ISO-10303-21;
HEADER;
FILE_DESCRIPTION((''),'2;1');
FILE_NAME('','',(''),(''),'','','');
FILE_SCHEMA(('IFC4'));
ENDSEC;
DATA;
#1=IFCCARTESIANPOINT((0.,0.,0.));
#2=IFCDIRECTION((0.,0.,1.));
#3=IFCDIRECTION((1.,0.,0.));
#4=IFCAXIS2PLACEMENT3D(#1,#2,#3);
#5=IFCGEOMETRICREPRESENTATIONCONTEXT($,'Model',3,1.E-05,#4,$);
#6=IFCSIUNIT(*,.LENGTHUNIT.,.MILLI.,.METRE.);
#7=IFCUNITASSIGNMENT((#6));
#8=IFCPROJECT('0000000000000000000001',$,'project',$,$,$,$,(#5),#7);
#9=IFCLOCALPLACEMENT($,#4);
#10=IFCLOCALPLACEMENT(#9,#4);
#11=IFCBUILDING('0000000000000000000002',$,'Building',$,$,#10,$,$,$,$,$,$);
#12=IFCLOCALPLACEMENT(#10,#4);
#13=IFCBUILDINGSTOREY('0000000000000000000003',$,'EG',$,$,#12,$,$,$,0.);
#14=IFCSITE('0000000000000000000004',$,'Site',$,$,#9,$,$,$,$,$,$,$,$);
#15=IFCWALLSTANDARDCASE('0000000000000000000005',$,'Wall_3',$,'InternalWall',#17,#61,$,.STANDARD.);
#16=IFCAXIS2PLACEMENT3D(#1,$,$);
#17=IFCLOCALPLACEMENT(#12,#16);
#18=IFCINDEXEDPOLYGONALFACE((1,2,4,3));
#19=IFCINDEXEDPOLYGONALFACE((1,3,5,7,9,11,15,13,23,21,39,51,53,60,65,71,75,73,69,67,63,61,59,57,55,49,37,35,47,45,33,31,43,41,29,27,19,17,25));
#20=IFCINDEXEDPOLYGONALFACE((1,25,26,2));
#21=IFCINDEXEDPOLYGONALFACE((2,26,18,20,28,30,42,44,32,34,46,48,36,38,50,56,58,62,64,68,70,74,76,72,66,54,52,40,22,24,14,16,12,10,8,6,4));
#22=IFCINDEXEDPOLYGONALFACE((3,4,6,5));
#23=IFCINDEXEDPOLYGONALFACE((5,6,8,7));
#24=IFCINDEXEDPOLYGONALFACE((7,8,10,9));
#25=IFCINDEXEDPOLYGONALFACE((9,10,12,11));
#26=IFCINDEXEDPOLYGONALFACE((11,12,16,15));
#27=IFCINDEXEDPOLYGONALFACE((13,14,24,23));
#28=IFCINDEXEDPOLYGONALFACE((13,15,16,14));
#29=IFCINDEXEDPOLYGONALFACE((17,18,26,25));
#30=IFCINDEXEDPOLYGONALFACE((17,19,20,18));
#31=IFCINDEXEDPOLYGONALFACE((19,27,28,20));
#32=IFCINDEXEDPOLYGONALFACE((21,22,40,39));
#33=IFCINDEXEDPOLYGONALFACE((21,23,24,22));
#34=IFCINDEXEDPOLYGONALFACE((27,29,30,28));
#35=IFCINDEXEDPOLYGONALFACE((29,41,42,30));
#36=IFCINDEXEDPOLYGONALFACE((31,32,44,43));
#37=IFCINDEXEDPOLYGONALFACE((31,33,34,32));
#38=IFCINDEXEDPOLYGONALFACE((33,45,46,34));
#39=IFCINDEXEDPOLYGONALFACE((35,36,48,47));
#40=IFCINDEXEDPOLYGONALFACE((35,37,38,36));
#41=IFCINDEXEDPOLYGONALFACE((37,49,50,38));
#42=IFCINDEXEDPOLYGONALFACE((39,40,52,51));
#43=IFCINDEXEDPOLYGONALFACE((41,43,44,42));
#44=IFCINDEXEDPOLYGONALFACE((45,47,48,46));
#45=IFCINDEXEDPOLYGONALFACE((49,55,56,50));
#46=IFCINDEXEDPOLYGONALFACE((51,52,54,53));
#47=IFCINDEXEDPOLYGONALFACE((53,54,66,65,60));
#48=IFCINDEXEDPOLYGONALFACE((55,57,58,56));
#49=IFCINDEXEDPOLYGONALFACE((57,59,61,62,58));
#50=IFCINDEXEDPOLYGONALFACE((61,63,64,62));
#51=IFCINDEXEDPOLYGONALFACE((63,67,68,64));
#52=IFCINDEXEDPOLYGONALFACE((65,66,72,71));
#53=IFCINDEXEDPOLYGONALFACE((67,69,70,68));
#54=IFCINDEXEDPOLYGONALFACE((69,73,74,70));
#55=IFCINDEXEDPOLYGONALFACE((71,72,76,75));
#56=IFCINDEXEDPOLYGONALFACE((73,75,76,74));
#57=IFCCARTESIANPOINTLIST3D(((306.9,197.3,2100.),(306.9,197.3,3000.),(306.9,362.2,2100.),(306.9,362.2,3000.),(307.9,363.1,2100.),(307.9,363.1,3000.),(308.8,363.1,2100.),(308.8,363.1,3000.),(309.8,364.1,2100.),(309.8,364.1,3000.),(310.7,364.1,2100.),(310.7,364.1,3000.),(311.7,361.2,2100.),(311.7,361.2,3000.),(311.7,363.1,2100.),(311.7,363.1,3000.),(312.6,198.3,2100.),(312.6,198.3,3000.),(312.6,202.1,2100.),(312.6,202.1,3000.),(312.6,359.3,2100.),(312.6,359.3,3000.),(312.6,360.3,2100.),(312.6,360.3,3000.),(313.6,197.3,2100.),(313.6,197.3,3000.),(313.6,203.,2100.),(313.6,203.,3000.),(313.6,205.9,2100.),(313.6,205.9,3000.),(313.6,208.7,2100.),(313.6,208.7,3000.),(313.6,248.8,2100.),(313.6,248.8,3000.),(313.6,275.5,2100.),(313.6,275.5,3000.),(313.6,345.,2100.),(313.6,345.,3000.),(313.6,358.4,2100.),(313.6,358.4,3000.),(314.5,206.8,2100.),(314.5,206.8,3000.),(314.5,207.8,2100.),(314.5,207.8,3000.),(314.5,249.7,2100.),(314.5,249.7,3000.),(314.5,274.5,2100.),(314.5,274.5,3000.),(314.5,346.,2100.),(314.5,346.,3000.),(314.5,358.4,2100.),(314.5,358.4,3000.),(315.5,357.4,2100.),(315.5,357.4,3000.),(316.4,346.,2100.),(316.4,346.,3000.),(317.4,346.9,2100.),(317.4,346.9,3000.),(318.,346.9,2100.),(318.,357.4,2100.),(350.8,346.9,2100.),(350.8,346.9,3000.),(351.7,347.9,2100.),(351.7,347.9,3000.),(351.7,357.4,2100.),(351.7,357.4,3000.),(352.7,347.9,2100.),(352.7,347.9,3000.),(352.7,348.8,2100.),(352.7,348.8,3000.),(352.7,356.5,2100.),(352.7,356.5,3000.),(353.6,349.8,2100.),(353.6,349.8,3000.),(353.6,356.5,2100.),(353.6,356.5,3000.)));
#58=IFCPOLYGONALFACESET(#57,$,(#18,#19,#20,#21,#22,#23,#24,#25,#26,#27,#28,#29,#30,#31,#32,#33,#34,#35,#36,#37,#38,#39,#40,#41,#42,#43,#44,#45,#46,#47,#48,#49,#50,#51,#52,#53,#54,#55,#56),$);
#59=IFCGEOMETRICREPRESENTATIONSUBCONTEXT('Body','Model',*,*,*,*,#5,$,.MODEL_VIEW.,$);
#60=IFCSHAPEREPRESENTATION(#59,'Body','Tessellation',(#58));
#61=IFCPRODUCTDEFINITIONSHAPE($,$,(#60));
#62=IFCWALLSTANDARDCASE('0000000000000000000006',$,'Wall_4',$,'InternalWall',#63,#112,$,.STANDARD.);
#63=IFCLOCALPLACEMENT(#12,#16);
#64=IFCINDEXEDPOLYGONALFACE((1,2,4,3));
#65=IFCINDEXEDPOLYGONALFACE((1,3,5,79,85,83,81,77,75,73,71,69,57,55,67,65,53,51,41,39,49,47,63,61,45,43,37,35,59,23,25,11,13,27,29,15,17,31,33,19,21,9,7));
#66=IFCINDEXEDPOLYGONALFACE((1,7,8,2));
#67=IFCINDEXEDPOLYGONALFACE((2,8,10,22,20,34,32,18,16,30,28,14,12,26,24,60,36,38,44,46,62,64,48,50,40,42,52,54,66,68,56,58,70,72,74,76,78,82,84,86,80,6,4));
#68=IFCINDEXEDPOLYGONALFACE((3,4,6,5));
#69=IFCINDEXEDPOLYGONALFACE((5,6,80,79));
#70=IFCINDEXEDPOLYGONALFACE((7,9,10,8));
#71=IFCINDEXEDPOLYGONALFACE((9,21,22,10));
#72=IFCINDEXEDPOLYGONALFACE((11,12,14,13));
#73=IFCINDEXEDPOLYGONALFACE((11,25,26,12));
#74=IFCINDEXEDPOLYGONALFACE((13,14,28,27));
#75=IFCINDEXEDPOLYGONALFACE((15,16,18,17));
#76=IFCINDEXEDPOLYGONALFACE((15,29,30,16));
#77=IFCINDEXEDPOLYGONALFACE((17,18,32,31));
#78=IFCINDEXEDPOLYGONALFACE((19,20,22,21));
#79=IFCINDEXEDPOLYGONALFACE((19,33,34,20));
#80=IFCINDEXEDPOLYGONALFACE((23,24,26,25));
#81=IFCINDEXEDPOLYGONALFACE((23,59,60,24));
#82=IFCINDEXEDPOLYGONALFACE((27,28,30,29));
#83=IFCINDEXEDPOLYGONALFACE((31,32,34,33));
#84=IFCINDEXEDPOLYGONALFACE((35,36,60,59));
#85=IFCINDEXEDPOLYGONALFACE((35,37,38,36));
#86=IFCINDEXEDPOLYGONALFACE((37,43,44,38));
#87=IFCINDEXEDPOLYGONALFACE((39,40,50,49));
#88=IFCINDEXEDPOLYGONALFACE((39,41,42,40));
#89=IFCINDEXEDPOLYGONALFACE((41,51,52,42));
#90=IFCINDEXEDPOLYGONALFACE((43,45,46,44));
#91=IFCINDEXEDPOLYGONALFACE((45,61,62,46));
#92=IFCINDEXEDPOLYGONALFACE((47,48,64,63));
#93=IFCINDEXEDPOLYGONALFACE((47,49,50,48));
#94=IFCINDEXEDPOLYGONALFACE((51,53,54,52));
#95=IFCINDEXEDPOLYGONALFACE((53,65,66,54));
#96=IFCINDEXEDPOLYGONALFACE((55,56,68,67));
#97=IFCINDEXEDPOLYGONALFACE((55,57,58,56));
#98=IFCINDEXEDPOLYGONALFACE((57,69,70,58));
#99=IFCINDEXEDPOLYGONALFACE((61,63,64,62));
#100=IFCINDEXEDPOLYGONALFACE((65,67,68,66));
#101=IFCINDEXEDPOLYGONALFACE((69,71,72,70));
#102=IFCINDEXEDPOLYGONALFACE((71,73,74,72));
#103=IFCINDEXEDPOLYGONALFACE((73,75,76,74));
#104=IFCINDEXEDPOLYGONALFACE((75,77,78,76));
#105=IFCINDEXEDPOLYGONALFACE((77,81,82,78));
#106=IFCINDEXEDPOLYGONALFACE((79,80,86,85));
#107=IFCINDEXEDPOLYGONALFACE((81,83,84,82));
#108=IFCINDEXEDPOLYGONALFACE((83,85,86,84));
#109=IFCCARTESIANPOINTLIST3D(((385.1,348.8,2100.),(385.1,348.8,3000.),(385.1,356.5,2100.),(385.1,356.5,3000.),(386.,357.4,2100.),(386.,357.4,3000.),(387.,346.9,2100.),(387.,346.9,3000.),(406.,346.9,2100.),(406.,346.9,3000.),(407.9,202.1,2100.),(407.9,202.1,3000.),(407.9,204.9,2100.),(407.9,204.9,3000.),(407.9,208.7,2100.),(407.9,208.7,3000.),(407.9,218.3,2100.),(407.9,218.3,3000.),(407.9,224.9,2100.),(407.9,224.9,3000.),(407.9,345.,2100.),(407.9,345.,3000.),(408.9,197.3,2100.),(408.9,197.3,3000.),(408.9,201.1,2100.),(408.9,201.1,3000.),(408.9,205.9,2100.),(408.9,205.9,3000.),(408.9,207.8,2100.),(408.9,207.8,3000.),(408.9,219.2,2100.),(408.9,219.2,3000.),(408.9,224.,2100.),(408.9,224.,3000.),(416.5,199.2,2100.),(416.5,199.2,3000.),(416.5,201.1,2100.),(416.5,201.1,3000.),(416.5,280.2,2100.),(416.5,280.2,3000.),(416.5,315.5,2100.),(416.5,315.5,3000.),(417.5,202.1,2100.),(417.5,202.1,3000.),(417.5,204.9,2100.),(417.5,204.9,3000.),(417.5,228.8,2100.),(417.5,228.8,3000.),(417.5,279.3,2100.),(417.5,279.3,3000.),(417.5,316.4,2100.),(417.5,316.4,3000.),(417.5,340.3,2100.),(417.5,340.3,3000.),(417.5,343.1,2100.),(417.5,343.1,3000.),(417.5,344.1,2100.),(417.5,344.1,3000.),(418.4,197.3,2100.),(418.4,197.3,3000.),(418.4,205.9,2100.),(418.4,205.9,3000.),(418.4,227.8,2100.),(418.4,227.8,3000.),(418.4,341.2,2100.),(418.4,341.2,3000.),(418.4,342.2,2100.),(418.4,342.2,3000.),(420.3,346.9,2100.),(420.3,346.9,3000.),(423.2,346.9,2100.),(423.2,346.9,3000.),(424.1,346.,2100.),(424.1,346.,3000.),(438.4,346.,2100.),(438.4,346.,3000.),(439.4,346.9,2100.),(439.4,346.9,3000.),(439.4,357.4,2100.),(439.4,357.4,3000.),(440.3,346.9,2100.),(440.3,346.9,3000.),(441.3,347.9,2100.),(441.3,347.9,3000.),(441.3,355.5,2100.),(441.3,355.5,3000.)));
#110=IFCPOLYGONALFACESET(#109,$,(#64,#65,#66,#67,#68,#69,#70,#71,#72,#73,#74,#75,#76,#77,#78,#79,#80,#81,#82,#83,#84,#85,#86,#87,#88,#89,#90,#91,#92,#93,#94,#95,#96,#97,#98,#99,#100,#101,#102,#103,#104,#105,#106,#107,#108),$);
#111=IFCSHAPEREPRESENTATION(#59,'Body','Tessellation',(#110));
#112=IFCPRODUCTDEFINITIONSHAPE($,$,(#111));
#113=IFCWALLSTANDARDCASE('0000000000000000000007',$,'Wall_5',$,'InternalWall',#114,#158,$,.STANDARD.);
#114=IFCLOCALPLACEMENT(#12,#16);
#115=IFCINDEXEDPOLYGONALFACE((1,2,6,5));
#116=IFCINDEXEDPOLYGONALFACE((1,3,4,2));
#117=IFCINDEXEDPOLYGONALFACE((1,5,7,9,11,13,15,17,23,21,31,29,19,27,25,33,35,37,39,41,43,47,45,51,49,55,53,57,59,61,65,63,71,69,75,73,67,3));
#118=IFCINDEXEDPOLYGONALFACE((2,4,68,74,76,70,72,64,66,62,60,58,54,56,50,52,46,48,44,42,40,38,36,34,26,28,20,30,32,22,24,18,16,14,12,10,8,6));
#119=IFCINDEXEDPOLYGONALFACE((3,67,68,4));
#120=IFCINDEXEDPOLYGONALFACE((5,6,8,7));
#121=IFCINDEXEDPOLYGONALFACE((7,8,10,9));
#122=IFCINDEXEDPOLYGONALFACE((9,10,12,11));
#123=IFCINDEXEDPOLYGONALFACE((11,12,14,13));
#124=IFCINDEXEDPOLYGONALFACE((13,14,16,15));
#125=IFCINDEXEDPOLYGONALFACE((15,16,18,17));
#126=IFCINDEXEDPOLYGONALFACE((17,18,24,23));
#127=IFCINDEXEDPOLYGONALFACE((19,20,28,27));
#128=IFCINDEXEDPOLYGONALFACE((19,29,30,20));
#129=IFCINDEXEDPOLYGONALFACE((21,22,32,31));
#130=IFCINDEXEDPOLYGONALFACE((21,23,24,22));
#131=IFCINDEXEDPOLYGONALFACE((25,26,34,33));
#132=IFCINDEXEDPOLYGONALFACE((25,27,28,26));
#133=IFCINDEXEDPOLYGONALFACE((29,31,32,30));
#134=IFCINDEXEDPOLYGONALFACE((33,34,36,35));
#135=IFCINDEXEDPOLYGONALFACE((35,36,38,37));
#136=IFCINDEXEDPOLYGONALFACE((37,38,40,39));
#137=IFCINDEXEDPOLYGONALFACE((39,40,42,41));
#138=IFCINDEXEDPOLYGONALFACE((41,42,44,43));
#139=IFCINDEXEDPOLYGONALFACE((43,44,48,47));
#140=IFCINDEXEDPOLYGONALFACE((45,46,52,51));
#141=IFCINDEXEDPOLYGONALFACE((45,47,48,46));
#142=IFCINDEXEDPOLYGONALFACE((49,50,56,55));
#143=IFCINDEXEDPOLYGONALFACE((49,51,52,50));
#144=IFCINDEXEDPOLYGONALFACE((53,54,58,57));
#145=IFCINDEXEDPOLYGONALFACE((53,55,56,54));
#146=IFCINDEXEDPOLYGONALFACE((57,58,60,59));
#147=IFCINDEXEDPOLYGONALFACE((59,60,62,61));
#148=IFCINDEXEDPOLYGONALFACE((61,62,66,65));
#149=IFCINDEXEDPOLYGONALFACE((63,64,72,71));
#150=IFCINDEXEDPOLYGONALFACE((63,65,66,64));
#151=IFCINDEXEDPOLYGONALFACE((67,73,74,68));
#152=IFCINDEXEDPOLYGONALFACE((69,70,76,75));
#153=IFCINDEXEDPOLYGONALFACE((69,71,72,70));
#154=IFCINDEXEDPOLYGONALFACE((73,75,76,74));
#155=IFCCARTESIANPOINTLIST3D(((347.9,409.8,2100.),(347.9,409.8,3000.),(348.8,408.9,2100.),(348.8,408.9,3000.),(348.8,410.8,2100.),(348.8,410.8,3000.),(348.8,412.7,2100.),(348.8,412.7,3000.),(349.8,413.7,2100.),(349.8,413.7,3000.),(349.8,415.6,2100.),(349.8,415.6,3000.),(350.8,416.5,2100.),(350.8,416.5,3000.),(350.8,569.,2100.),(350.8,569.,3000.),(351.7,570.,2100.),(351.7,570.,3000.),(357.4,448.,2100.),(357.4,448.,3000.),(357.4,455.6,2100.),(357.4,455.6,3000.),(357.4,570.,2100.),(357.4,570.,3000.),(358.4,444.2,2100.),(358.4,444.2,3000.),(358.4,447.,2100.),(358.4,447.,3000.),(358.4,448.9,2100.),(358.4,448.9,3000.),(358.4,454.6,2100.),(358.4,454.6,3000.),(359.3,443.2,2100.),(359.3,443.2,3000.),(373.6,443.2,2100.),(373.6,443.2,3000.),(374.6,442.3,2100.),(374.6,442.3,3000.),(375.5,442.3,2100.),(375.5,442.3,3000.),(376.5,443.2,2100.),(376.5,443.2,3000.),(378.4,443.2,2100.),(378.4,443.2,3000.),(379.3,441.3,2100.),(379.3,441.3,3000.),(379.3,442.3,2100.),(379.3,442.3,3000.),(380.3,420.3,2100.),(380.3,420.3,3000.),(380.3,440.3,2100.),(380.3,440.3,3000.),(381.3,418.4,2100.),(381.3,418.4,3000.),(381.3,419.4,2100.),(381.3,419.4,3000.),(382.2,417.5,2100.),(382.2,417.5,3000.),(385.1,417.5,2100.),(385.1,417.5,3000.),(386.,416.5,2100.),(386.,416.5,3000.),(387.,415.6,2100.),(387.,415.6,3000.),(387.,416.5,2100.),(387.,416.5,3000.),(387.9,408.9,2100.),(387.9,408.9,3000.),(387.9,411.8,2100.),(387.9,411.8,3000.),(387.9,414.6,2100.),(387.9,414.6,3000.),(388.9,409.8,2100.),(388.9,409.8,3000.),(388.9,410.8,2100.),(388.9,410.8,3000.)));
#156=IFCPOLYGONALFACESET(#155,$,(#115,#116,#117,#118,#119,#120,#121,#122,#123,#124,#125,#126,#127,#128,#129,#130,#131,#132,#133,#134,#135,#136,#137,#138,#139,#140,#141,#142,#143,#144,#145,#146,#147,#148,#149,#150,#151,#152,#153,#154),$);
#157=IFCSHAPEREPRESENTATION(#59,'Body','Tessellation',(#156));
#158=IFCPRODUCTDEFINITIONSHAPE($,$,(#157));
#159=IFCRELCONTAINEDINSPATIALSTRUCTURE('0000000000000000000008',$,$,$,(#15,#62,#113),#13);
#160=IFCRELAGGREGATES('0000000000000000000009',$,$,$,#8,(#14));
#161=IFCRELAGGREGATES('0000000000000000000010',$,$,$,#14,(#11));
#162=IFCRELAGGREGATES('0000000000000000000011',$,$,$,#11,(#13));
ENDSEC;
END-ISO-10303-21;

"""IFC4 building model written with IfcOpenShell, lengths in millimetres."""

from ifc_helpers import new_model, si_unit, frame, origin_with_axes, place, context, subcontext, project, spatial, polyline, rectangle, outline, extrude, element, save


model = new_model("IFC4")

# Units and contexts
model_context = context("Model", 3, precision=1e-05, world=origin_with_axes())
body_context = subcontext(model_context, "Body", "Model", "MODEL_VIEW")
ifc_project = project(units=[si_unit("LENGTHUNIT", "METRE", prefix="MILLI")], contexts=[model_context])

# Site, building, storey
site_placement = place(None, origin_with_axes())
site = spatial("IfcSite", under=ifc_project, at=site_placement, Name="Site")
building_placement = place(site_placement, origin_with_axes())
building = spatial("IfcBuilding", under=site, at=building_placement, Name="Building")
storey_placement = place(building_placement, origin_with_axes())
storey = spatial("IfcBuildingStorey", under=building, at=storey_placement, Name="EG", Elevation=0.0)

# Wall, openings
wall_1_placement = place(storey_placement, origin_with_axes())
wall_1 = element("IfcWallStandardCase", 1, at=wall_1_placement, inside=storey, Name="Wall_3", ObjectType="InternalWall", PredefinedType="STANDARD", context=body_context, shape_type="SweptSolid", body=[
    extrude(outline(polyline([(306.9, 197.3, 0.0), (306.9, 362.2, 0.0), (307.9, 363.1, 0.0), (308.8, 363.1, 0.0), (309.8, 364.1, 0.0), (310.7, 364.1, 0.0), (311.7, 363.1, 0.0), (311.7, 361.2, 0.0), (312.6, 360.3, 0.0), (312.6, 359.3, 0.0), (313.6, 358.4, 0.0), (314.5, 358.4, 0.0), (315.5, 357.4, 0.0), (351.7, 357.4, 0.0), (352.7, 356.5, 0.0), (353.6, 356.5, 0.0), (353.6, 349.8, 0.0), (352.7, 348.8, 0.0), (352.7, 347.9, 0.0), (351.7, 347.9, 0.0), (350.8, 346.9, 0.0), (317.4, 346.9, 0.0), (316.4, 346.0, 0.0), (314.5, 346.0, 0.0), (313.6, 345.0, 0.0), (313.6, 275.5, 0.0), (314.5, 274.5, 0.0), (314.5, 249.7, 0.0), (313.6, 248.8, 0.0), (313.6, 208.7, 0.0), (314.5, 207.8, 0.0), (314.5, 206.8, 0.0), (313.6, 205.9, 0.0), (313.6, 203.0, 0.0), (312.6, 202.1, 0.0), (312.6, 198.3, 0.0), (313.6, 197.3, 0.0), (306.9, 197.3, 0.0)])), origin_with_axes(), (0.0, 0.0, 1.0), 3000.0),
])
opening_1_placement = place(wall_1_placement, origin_with_axes())
element("IfcOpeningElement", 2, at=opening_1_placement, inside=storey, cuts=wall_1, context=body_context, shape_type="SweptSolid", body=[
    extrude(rectangle(XDim=450.0, YDim=46.7), frame((330.3, 337.4, 0.0), z_axis=(0.0, 0.0, 1.0), x_axis=(0.0, 1.0, 0.0)), (0.0, 0.0, 1.0), 2100.0),
])
opening_2_placement = place(wall_1_placement, origin_with_axes())
element("IfcOpeningElement", 3, at=opening_2_placement, inside=storey, cuts=wall_1, context=body_context, shape_type="SweptSolid", body=[
    extrude(rectangle(XDim=900.0, YDim=46.7), frame((294.6, 386.3, 0.0), z_axis=(0.0, 0.0, 1.0), x_axis=(0.0, 1.0, 0.0)), (0.0, 0.0, 1.0), 2100.0),
])

# Walls, openings
wall_2_placement = place(storey_placement, origin_with_axes())
wall_2 = element("IfcWallStandardCase", 4, at=wall_2_placement, inside=storey, Name="Wall_4", ObjectType="InternalWall", PredefinedType="STANDARD", context=body_context, shape_type="SweptSolid", body=[
    extrude(outline(polyline([(408.9, 197.3, 0.0), (408.9, 201.1, 0.0), (407.9, 202.1, 0.0), (407.9, 204.9, 0.0), (408.9, 205.9, 0.0), (408.9, 207.8, 0.0), (407.9, 208.7, 0.0), (407.9, 218.3, 0.0), (408.9, 219.2, 0.0), (408.9, 224.0, 0.0), (407.9, 224.9, 0.0), (407.9, 345.0, 0.0), (406.0, 346.9, 0.0), (387.0, 346.9, 0.0), (385.1, 348.8, 0.0), (385.1, 356.5, 0.0), (386.0, 357.4, 0.0), (439.4, 357.4, 0.0), (441.3, 355.5, 0.0), (441.3, 347.9, 0.0), (440.3, 346.9, 0.0), (439.4, 346.9, 0.0), (438.4, 346.0, 0.0), (424.1, 346.0, 0.0), (423.2, 346.9, 0.0), (420.3, 346.9, 0.0), (417.5, 344.1, 0.0), (417.5, 343.1, 0.0), (418.4, 342.2, 0.0), (418.4, 341.2, 0.0), (417.5, 340.3, 0.0), (417.5, 316.4, 0.0), (416.5, 315.5, 0.0), (416.5, 280.2, 0.0), (417.5, 279.3, 0.0), (417.5, 228.8, 0.0), (418.4, 227.8, 0.0), (418.4, 205.9, 0.0), (417.5, 204.9, 0.0), (417.5, 202.1, 0.0), (416.5, 201.1, 0.0), (416.5, 199.2, 0.0), (418.4, 197.3, 0.0), (423.2, 197.3, 0.0), (408.9, 197.3, 0.0)])), origin_with_axes(), (0.0, 0.0, 1.0), 3000.0),
])
opening_3_placement = place(wall_2_placement, origin_with_axes())
element("IfcOpeningElement", 5, at=opening_3_placement, inside=storey, cuts=wall_2, context=body_context, shape_type="SweptSolid", body=[
    extrude(rectangle(XDim=450.0, YDim=56.2), frame((413.2, 335.5, 0.0), z_axis=(0.0, 0.0, 1.0), x_axis=(0.0, 1.0, 0.0)), (0.0, 0.0, 1.0), 2100.0),
])
wall_3_placement = place(storey_placement, origin_with_axes())
wall_3 = element("IfcWallStandardCase", 6, at=wall_3_placement, inside=storey, Name="Wall_5", ObjectType="InternalWall", PredefinedType="STANDARD", context=body_context, shape_type="SweptSolid", body=[
    extrude(outline(polyline([(348.8, 408.9, 0.0), (347.9, 409.8, 0.0), (348.8, 410.8, 0.0), (348.8, 412.7, 0.0), (349.8, 413.7, 0.0), (349.8, 415.6, 0.0), (350.8, 416.5, 0.0), (350.8, 569.0, 0.0), (351.7, 570.0, 0.0), (357.4, 570.0, 0.0), (357.4, 455.6, 0.0), (358.4, 454.6, 0.0), (358.4, 448.9, 0.0), (357.4, 448.0, 0.0), (358.4, 447.0, 0.0), (358.4, 444.2, 0.0), (359.3, 443.2, 0.0), (373.6, 443.2, 0.0), (374.6, 442.3, 0.0), (375.5, 442.3, 0.0), (376.5, 443.2, 0.0), (378.4, 443.2, 0.0), (379.3, 442.3, 0.0), (379.3, 441.3, 0.0), (380.3, 440.3, 0.0), (380.3, 420.3, 0.0), (381.3, 419.4, 0.0), (381.3, 418.4, 0.0), (382.2, 417.5, 0.0), (385.1, 417.5, 0.0), (386.0, 416.5, 0.0), (387.0, 416.5, 0.0), (387.0, 415.6, 0.0), (387.9, 414.6, 0.0), (387.9, 411.8, 0.0), (388.9, 410.8, 0.0), (388.9, 409.8, 0.0), (387.9, 408.9, 0.0), (348.8, 408.9, 0.0)])), origin_with_axes(), (0.0, 0.0, 1.0), 3000.0),
])
opening_4_placement = place(wall_3_placement, origin_with_axes())
element("IfcOpeningElement", 7, at=opening_4_placement, inside=storey, cuts=wall_3, context=body_context, shape_type="SweptSolid", body=[
    extrude(rectangle(XDim=450.0, YDim=41.0), frame((368.4, 428.9, 0.0), z_axis=(0.0, 0.0, 1.0), x_axis=(0.0, -1.0, 0.0)), (0.0, 0.0, 1.0), 2100.0),
])

save(model, "model.ifc")
